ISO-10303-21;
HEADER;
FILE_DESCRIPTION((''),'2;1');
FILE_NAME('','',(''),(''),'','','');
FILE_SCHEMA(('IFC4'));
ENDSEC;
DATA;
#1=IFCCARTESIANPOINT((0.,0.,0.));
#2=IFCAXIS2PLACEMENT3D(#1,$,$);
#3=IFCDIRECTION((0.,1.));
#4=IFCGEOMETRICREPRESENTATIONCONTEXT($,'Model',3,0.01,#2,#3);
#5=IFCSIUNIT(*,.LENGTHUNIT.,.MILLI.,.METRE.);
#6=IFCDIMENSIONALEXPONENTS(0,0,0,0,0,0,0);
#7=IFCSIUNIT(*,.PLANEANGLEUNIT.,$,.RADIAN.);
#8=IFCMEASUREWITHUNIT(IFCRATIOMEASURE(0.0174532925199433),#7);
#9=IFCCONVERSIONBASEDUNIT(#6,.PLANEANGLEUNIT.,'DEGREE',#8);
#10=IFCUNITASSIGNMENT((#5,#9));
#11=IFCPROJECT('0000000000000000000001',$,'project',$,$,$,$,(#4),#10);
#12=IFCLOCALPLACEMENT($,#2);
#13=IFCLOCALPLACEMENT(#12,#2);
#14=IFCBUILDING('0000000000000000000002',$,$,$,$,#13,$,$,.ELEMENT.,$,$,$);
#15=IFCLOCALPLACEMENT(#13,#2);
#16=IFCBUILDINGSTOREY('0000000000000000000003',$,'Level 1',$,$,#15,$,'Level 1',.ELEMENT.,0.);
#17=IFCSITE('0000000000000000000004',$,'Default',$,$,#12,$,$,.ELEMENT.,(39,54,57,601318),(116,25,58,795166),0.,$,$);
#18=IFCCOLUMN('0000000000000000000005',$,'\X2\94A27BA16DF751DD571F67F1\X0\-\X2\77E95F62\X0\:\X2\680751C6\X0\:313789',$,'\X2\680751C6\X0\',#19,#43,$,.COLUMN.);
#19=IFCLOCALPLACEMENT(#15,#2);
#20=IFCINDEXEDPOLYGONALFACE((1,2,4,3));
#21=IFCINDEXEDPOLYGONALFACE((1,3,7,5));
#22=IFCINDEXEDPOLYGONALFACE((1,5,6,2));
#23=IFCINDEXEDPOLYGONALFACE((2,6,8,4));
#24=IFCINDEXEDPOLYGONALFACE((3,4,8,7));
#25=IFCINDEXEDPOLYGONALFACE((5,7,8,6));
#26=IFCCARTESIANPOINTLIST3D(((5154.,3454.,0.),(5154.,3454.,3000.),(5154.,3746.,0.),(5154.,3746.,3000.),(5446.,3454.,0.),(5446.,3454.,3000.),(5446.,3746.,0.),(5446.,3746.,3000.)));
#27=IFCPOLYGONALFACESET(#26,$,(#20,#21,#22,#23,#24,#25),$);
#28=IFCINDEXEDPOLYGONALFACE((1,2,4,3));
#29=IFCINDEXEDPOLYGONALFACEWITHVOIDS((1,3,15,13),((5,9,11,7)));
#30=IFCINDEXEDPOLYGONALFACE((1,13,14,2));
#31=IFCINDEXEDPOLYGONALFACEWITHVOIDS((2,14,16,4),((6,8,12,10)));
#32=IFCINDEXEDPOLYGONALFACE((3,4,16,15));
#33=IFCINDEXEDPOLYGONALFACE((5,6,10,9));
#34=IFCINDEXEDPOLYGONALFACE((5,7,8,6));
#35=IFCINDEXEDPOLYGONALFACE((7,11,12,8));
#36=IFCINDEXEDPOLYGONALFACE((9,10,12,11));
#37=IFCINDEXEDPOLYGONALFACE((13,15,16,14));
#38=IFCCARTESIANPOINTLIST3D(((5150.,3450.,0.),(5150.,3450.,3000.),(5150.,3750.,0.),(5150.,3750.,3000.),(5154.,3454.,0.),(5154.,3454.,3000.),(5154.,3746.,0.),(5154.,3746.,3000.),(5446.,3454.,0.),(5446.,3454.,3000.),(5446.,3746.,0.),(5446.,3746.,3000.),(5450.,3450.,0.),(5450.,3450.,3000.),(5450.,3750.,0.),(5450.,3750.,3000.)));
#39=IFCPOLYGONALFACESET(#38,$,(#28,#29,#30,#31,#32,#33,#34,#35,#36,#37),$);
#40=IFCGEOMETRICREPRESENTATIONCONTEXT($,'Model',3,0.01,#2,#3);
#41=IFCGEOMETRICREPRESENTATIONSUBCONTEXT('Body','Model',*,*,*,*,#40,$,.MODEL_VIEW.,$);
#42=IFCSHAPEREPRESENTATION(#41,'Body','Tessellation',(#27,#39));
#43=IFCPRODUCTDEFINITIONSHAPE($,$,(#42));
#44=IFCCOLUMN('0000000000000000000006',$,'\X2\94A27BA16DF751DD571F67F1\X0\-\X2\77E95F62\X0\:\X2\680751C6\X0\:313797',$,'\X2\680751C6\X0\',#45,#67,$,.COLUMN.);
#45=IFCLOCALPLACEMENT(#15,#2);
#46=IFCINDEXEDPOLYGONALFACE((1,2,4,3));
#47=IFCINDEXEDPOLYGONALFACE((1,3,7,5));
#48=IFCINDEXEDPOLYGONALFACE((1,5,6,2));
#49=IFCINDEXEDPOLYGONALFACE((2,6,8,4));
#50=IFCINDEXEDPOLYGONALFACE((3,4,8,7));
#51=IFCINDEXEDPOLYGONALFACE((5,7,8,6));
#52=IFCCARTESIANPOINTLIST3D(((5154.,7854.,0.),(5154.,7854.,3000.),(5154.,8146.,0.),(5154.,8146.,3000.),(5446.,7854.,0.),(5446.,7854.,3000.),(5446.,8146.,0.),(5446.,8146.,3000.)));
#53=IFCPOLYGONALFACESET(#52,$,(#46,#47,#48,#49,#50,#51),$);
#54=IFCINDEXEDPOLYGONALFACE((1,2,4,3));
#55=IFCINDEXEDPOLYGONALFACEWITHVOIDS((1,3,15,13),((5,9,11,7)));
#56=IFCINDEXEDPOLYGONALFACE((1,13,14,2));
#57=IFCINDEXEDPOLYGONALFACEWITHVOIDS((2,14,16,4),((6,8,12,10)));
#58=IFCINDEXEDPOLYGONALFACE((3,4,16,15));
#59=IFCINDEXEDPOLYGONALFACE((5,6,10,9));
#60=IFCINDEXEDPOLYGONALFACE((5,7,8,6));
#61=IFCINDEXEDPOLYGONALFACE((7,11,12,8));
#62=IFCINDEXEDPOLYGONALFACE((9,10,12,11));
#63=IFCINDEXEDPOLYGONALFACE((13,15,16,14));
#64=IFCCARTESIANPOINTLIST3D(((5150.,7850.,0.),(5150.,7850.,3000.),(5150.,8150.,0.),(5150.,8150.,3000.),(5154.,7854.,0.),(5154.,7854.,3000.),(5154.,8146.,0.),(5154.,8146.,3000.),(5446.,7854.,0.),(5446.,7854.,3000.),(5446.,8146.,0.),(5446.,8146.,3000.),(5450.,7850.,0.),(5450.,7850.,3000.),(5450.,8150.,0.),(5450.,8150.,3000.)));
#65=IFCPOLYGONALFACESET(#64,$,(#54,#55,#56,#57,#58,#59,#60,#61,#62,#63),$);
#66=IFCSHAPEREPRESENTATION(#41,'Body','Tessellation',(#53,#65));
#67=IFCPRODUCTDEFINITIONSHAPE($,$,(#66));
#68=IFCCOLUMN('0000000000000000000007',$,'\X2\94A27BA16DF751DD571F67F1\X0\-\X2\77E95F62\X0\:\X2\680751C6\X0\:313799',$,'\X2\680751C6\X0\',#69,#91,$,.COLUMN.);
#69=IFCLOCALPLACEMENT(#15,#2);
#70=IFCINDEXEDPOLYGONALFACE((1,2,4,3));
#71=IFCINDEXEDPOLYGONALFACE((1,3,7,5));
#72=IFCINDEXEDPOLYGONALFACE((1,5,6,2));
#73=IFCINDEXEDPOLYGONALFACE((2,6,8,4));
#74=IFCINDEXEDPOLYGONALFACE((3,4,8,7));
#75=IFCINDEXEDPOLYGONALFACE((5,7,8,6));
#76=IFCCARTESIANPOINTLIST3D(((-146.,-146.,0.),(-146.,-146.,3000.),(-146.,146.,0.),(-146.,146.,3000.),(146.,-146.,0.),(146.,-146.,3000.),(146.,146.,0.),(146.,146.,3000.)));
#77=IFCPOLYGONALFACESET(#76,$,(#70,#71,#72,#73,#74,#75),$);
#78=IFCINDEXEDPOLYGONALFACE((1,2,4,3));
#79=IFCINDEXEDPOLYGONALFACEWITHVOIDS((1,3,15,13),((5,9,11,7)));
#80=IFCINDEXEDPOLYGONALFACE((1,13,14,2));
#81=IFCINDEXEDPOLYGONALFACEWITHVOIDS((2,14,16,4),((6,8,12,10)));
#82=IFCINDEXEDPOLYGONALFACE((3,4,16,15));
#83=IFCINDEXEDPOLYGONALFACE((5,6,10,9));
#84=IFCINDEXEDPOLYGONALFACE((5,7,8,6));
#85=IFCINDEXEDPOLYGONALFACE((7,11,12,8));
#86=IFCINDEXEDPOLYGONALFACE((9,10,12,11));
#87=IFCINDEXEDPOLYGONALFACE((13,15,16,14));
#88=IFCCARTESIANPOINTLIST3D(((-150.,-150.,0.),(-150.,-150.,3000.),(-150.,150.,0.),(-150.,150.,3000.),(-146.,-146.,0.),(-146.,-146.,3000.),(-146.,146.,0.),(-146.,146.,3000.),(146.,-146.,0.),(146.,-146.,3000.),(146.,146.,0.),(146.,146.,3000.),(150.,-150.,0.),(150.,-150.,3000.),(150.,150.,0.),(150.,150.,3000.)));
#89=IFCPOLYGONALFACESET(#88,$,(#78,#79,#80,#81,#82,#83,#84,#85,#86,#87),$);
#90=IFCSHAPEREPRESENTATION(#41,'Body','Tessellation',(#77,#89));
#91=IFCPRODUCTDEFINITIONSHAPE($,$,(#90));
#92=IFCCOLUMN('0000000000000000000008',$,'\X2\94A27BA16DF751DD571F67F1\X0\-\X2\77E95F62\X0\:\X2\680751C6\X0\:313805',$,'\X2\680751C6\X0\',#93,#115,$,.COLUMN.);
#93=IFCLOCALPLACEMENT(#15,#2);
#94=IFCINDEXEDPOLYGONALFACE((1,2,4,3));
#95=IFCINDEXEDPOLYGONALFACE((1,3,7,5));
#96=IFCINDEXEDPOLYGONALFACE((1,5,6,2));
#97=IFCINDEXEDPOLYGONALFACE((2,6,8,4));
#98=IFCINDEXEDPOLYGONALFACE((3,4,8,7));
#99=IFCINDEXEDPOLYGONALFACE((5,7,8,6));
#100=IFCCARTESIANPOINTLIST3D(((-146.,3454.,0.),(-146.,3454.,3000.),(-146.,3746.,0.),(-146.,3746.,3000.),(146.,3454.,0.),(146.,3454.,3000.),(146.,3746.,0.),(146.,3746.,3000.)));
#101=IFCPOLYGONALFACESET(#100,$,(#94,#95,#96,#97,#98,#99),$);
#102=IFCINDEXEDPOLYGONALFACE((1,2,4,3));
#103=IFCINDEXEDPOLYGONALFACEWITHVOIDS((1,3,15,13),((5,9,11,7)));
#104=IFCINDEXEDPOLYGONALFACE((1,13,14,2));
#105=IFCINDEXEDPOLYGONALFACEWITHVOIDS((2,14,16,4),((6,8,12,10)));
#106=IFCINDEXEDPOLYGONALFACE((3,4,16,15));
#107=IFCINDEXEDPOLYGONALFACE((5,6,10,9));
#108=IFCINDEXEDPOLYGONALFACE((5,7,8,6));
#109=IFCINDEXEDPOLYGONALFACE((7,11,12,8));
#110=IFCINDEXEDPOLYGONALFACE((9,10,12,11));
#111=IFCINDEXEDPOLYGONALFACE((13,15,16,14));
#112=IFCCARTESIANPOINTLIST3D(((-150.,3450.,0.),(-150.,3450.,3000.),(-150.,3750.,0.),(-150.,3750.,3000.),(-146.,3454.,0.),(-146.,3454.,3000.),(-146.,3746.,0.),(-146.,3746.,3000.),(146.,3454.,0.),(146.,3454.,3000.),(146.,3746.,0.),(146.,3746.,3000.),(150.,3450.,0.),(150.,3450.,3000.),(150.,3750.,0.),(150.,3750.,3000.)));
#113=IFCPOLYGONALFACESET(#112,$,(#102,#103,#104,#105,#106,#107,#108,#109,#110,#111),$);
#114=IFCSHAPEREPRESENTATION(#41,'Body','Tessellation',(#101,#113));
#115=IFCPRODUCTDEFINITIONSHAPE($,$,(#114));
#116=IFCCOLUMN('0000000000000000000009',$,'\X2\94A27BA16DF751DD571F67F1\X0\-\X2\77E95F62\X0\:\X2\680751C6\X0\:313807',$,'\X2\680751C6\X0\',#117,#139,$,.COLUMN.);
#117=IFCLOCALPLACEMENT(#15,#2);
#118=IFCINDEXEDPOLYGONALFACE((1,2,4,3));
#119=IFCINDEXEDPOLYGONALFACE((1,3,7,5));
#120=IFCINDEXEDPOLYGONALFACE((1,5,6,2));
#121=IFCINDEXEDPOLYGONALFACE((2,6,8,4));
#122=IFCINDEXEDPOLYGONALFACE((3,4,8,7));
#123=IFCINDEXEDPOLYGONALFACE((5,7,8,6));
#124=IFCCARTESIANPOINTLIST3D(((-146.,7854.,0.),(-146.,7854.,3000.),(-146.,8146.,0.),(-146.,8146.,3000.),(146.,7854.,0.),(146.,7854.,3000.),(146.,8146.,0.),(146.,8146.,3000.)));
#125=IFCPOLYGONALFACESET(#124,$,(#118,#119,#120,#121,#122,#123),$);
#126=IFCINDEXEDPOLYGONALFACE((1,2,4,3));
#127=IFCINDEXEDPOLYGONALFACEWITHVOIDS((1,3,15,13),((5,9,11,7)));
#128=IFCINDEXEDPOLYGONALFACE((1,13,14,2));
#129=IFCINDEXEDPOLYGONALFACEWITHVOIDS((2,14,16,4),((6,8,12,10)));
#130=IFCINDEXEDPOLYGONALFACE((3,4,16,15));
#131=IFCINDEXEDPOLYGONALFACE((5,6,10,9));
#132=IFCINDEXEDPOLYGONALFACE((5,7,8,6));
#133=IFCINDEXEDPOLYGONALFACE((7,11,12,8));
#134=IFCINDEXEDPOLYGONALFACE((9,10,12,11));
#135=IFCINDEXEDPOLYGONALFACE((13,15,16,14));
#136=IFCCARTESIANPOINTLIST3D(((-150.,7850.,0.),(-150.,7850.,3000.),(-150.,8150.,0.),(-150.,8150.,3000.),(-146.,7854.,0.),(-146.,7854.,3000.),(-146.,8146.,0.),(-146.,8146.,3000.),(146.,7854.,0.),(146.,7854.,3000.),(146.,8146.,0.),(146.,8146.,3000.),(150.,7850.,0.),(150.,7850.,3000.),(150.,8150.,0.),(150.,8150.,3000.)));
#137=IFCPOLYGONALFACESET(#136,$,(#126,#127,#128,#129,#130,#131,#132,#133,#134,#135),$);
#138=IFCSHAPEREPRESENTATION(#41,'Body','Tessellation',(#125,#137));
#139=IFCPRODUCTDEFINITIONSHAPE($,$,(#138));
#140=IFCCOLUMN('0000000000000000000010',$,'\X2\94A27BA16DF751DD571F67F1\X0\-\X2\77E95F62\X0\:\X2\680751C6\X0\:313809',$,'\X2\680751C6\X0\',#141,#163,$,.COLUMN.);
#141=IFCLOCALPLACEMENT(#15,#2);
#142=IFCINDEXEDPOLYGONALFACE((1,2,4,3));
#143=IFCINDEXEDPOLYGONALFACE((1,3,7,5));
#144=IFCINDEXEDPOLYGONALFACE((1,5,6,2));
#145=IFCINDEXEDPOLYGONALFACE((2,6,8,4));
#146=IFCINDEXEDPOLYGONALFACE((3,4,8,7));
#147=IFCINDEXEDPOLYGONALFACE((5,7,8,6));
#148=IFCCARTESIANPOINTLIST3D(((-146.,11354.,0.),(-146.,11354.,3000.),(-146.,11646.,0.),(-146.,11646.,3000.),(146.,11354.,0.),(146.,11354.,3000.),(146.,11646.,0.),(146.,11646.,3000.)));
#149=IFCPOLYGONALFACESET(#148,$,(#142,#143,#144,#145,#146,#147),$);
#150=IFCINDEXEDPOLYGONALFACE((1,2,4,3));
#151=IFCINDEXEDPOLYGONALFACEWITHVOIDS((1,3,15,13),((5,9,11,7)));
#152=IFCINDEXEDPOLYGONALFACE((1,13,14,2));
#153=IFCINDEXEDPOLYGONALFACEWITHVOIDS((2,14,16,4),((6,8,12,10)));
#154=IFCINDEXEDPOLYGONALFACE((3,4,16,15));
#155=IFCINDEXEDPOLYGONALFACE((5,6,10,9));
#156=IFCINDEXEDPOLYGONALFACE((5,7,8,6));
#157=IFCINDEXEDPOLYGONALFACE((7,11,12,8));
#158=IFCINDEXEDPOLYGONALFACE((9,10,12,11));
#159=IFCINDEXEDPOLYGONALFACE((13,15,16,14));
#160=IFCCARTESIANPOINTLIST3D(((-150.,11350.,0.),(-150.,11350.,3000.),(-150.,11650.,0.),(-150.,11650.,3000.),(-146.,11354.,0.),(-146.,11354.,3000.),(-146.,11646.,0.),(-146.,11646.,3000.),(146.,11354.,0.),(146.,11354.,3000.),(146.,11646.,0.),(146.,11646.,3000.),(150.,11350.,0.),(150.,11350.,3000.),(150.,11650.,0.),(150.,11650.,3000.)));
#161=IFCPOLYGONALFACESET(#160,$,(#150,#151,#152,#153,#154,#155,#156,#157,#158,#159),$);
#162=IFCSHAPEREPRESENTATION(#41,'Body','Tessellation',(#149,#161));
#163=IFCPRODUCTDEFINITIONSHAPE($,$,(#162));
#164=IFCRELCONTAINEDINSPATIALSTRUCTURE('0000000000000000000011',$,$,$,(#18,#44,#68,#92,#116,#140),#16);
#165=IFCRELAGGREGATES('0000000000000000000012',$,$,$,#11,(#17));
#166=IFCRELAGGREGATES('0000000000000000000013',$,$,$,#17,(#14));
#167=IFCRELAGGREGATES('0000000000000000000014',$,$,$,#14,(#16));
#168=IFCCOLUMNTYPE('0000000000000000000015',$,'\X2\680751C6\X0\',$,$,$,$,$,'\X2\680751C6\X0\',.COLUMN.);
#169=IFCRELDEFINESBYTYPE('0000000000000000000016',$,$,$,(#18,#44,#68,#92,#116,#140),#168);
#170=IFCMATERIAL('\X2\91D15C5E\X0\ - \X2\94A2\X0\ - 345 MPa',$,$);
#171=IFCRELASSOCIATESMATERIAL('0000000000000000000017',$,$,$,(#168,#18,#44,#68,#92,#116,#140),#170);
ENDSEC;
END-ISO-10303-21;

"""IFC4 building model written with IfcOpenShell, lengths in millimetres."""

from ifc_helpers import new_model, entity, si_unit, converted_unit, direction, frame, origin, origin_2d_with_axis, place, context, subcontext, project, spatial, polyline, rectangle, outline, extrude, source, transform, mapped, material, type_object, type_shapes, element, save


model = new_model("IFC4")

# Units and contexts
model_context_1 = context("Model", 3, precision=0.01, world=origin(), true_north=direction((0.0, 1.0)))
model_context_2 = context("Model", 3, precision=0.01, world=origin(), true_north=direction((0.0, 1.0)))
body_context_1 = subcontext(model_context_2, "Body", "Model", "MODEL_VIEW")
ifc_project = project(units=[si_unit("LENGTHUNIT", "METRE", prefix="MILLI"), converted_unit("PLANEANGLEUNIT", "DEGREE", entity("IfcRatioMeasure", 0.0174532925199433), si_unit("PLANEANGLEUNIT", "RADIAN"), dimensions=[0, 0, 0, 0, 0, 0, 0])], contexts=[model_context_1])

# Site, building, storey
site_placement = place(None, origin())
site = spatial("IfcSite", under=ifc_project, at=site_placement, Name="Default", CompositionType="ELEMENT", RefLatitude=(39, 54, 57, 601318), RefLongitude=(116, 25, 58, 795166), RefElevation=0.0)
building_placement = place(site_placement, origin())
building = spatial("IfcBuilding", under=site, at=building_placement, CompositionType="ELEMENT")
storey_placement = place(building_placement, origin())
storey = spatial("IfcBuildingStorey", under=building, at=storey_placement, Name="Level 1", LongName="Level 1", CompositionType="ELEMENT", Elevation=0.0)

# Columns
ifc_material_1 = material(Name="金属 - 钢 - 345 MPa")
column_type = type_object("IfcColumnType", Name="标准", ElementType="标准", PredefinedType="COLUMN", material=ifc_material_1)
shared_shape_1 = source(origin(), body_context_1, "Body", "SweptSolid", [
    extrude(rectangle(XDim=292.0, YDim=292.0, at=origin_2d_with_axis()), frame((0.0, 0.0, 0.0), z_axis=(0.0, 0.0, 1.0), x_axis=(-1.0, 0.0, 0.0)), (0.0, 0.0, 1.0), 3000.0),
    extrude(outline(polyline([(-150.0, -150.0), (150.0, -150.0), (150.0, 150.0), (-150.0, 150.0), (-150.0, -150.0)]), holes=[polyline([(-146.0, -146.0), (-146.0, 146.0), (146.0, 146.0), (146.0, -146.0), (-146.0, -146.0)])]), frame((0.0, 0.0, 0.0), z_axis=(0.0, 0.0, 1.0), x_axis=(-1.0, 0.0, 0.0)), (0.0, 0.0, 1.0), 3000.0),
])
type_shapes(column_type, [shared_shape_1])
placement_1 = place(None, origin())
placement_2 = place(placement_1, origin())
placement_3 = place(placement_2, origin())
for number, where, name in (
    (1, (5300.0, 3600.0, 0.0), "钢管混凝土柱-矩形:标准:313789"),
    (2, (5300.0, 8000.0, 0.0), "钢管混凝土柱-矩形:标准:313797"),
    (3, (0.0, 0.0, 0.0), "钢管混凝土柱-矩形:标准:313799"),
    (4, (0.0, 3600.0, 0.0), "钢管混凝土柱-矩形:标准:313805"),
    (5, (0.0, 8000.0, 0.0), "钢管混凝土柱-矩形:标准:313807"),
    (6, (0.0, 11500.0, 0.0), "钢管混凝土柱-矩形:标准:313809"),
):
    element("IfcColumn", number, at=place(placement_3, frame(where)), inside=storey, type_object=column_type, material=ifc_material_1, Name=name, ObjectType="标准", PredefinedType="COLUMN", context=body_context_1, shape_type="MappedRepresentation", body=[
        mapped(shared_shape_1, transform((0.0, 0.0, 0.0), scale=1.0)),
    ])

save(model, "model.ifc")
